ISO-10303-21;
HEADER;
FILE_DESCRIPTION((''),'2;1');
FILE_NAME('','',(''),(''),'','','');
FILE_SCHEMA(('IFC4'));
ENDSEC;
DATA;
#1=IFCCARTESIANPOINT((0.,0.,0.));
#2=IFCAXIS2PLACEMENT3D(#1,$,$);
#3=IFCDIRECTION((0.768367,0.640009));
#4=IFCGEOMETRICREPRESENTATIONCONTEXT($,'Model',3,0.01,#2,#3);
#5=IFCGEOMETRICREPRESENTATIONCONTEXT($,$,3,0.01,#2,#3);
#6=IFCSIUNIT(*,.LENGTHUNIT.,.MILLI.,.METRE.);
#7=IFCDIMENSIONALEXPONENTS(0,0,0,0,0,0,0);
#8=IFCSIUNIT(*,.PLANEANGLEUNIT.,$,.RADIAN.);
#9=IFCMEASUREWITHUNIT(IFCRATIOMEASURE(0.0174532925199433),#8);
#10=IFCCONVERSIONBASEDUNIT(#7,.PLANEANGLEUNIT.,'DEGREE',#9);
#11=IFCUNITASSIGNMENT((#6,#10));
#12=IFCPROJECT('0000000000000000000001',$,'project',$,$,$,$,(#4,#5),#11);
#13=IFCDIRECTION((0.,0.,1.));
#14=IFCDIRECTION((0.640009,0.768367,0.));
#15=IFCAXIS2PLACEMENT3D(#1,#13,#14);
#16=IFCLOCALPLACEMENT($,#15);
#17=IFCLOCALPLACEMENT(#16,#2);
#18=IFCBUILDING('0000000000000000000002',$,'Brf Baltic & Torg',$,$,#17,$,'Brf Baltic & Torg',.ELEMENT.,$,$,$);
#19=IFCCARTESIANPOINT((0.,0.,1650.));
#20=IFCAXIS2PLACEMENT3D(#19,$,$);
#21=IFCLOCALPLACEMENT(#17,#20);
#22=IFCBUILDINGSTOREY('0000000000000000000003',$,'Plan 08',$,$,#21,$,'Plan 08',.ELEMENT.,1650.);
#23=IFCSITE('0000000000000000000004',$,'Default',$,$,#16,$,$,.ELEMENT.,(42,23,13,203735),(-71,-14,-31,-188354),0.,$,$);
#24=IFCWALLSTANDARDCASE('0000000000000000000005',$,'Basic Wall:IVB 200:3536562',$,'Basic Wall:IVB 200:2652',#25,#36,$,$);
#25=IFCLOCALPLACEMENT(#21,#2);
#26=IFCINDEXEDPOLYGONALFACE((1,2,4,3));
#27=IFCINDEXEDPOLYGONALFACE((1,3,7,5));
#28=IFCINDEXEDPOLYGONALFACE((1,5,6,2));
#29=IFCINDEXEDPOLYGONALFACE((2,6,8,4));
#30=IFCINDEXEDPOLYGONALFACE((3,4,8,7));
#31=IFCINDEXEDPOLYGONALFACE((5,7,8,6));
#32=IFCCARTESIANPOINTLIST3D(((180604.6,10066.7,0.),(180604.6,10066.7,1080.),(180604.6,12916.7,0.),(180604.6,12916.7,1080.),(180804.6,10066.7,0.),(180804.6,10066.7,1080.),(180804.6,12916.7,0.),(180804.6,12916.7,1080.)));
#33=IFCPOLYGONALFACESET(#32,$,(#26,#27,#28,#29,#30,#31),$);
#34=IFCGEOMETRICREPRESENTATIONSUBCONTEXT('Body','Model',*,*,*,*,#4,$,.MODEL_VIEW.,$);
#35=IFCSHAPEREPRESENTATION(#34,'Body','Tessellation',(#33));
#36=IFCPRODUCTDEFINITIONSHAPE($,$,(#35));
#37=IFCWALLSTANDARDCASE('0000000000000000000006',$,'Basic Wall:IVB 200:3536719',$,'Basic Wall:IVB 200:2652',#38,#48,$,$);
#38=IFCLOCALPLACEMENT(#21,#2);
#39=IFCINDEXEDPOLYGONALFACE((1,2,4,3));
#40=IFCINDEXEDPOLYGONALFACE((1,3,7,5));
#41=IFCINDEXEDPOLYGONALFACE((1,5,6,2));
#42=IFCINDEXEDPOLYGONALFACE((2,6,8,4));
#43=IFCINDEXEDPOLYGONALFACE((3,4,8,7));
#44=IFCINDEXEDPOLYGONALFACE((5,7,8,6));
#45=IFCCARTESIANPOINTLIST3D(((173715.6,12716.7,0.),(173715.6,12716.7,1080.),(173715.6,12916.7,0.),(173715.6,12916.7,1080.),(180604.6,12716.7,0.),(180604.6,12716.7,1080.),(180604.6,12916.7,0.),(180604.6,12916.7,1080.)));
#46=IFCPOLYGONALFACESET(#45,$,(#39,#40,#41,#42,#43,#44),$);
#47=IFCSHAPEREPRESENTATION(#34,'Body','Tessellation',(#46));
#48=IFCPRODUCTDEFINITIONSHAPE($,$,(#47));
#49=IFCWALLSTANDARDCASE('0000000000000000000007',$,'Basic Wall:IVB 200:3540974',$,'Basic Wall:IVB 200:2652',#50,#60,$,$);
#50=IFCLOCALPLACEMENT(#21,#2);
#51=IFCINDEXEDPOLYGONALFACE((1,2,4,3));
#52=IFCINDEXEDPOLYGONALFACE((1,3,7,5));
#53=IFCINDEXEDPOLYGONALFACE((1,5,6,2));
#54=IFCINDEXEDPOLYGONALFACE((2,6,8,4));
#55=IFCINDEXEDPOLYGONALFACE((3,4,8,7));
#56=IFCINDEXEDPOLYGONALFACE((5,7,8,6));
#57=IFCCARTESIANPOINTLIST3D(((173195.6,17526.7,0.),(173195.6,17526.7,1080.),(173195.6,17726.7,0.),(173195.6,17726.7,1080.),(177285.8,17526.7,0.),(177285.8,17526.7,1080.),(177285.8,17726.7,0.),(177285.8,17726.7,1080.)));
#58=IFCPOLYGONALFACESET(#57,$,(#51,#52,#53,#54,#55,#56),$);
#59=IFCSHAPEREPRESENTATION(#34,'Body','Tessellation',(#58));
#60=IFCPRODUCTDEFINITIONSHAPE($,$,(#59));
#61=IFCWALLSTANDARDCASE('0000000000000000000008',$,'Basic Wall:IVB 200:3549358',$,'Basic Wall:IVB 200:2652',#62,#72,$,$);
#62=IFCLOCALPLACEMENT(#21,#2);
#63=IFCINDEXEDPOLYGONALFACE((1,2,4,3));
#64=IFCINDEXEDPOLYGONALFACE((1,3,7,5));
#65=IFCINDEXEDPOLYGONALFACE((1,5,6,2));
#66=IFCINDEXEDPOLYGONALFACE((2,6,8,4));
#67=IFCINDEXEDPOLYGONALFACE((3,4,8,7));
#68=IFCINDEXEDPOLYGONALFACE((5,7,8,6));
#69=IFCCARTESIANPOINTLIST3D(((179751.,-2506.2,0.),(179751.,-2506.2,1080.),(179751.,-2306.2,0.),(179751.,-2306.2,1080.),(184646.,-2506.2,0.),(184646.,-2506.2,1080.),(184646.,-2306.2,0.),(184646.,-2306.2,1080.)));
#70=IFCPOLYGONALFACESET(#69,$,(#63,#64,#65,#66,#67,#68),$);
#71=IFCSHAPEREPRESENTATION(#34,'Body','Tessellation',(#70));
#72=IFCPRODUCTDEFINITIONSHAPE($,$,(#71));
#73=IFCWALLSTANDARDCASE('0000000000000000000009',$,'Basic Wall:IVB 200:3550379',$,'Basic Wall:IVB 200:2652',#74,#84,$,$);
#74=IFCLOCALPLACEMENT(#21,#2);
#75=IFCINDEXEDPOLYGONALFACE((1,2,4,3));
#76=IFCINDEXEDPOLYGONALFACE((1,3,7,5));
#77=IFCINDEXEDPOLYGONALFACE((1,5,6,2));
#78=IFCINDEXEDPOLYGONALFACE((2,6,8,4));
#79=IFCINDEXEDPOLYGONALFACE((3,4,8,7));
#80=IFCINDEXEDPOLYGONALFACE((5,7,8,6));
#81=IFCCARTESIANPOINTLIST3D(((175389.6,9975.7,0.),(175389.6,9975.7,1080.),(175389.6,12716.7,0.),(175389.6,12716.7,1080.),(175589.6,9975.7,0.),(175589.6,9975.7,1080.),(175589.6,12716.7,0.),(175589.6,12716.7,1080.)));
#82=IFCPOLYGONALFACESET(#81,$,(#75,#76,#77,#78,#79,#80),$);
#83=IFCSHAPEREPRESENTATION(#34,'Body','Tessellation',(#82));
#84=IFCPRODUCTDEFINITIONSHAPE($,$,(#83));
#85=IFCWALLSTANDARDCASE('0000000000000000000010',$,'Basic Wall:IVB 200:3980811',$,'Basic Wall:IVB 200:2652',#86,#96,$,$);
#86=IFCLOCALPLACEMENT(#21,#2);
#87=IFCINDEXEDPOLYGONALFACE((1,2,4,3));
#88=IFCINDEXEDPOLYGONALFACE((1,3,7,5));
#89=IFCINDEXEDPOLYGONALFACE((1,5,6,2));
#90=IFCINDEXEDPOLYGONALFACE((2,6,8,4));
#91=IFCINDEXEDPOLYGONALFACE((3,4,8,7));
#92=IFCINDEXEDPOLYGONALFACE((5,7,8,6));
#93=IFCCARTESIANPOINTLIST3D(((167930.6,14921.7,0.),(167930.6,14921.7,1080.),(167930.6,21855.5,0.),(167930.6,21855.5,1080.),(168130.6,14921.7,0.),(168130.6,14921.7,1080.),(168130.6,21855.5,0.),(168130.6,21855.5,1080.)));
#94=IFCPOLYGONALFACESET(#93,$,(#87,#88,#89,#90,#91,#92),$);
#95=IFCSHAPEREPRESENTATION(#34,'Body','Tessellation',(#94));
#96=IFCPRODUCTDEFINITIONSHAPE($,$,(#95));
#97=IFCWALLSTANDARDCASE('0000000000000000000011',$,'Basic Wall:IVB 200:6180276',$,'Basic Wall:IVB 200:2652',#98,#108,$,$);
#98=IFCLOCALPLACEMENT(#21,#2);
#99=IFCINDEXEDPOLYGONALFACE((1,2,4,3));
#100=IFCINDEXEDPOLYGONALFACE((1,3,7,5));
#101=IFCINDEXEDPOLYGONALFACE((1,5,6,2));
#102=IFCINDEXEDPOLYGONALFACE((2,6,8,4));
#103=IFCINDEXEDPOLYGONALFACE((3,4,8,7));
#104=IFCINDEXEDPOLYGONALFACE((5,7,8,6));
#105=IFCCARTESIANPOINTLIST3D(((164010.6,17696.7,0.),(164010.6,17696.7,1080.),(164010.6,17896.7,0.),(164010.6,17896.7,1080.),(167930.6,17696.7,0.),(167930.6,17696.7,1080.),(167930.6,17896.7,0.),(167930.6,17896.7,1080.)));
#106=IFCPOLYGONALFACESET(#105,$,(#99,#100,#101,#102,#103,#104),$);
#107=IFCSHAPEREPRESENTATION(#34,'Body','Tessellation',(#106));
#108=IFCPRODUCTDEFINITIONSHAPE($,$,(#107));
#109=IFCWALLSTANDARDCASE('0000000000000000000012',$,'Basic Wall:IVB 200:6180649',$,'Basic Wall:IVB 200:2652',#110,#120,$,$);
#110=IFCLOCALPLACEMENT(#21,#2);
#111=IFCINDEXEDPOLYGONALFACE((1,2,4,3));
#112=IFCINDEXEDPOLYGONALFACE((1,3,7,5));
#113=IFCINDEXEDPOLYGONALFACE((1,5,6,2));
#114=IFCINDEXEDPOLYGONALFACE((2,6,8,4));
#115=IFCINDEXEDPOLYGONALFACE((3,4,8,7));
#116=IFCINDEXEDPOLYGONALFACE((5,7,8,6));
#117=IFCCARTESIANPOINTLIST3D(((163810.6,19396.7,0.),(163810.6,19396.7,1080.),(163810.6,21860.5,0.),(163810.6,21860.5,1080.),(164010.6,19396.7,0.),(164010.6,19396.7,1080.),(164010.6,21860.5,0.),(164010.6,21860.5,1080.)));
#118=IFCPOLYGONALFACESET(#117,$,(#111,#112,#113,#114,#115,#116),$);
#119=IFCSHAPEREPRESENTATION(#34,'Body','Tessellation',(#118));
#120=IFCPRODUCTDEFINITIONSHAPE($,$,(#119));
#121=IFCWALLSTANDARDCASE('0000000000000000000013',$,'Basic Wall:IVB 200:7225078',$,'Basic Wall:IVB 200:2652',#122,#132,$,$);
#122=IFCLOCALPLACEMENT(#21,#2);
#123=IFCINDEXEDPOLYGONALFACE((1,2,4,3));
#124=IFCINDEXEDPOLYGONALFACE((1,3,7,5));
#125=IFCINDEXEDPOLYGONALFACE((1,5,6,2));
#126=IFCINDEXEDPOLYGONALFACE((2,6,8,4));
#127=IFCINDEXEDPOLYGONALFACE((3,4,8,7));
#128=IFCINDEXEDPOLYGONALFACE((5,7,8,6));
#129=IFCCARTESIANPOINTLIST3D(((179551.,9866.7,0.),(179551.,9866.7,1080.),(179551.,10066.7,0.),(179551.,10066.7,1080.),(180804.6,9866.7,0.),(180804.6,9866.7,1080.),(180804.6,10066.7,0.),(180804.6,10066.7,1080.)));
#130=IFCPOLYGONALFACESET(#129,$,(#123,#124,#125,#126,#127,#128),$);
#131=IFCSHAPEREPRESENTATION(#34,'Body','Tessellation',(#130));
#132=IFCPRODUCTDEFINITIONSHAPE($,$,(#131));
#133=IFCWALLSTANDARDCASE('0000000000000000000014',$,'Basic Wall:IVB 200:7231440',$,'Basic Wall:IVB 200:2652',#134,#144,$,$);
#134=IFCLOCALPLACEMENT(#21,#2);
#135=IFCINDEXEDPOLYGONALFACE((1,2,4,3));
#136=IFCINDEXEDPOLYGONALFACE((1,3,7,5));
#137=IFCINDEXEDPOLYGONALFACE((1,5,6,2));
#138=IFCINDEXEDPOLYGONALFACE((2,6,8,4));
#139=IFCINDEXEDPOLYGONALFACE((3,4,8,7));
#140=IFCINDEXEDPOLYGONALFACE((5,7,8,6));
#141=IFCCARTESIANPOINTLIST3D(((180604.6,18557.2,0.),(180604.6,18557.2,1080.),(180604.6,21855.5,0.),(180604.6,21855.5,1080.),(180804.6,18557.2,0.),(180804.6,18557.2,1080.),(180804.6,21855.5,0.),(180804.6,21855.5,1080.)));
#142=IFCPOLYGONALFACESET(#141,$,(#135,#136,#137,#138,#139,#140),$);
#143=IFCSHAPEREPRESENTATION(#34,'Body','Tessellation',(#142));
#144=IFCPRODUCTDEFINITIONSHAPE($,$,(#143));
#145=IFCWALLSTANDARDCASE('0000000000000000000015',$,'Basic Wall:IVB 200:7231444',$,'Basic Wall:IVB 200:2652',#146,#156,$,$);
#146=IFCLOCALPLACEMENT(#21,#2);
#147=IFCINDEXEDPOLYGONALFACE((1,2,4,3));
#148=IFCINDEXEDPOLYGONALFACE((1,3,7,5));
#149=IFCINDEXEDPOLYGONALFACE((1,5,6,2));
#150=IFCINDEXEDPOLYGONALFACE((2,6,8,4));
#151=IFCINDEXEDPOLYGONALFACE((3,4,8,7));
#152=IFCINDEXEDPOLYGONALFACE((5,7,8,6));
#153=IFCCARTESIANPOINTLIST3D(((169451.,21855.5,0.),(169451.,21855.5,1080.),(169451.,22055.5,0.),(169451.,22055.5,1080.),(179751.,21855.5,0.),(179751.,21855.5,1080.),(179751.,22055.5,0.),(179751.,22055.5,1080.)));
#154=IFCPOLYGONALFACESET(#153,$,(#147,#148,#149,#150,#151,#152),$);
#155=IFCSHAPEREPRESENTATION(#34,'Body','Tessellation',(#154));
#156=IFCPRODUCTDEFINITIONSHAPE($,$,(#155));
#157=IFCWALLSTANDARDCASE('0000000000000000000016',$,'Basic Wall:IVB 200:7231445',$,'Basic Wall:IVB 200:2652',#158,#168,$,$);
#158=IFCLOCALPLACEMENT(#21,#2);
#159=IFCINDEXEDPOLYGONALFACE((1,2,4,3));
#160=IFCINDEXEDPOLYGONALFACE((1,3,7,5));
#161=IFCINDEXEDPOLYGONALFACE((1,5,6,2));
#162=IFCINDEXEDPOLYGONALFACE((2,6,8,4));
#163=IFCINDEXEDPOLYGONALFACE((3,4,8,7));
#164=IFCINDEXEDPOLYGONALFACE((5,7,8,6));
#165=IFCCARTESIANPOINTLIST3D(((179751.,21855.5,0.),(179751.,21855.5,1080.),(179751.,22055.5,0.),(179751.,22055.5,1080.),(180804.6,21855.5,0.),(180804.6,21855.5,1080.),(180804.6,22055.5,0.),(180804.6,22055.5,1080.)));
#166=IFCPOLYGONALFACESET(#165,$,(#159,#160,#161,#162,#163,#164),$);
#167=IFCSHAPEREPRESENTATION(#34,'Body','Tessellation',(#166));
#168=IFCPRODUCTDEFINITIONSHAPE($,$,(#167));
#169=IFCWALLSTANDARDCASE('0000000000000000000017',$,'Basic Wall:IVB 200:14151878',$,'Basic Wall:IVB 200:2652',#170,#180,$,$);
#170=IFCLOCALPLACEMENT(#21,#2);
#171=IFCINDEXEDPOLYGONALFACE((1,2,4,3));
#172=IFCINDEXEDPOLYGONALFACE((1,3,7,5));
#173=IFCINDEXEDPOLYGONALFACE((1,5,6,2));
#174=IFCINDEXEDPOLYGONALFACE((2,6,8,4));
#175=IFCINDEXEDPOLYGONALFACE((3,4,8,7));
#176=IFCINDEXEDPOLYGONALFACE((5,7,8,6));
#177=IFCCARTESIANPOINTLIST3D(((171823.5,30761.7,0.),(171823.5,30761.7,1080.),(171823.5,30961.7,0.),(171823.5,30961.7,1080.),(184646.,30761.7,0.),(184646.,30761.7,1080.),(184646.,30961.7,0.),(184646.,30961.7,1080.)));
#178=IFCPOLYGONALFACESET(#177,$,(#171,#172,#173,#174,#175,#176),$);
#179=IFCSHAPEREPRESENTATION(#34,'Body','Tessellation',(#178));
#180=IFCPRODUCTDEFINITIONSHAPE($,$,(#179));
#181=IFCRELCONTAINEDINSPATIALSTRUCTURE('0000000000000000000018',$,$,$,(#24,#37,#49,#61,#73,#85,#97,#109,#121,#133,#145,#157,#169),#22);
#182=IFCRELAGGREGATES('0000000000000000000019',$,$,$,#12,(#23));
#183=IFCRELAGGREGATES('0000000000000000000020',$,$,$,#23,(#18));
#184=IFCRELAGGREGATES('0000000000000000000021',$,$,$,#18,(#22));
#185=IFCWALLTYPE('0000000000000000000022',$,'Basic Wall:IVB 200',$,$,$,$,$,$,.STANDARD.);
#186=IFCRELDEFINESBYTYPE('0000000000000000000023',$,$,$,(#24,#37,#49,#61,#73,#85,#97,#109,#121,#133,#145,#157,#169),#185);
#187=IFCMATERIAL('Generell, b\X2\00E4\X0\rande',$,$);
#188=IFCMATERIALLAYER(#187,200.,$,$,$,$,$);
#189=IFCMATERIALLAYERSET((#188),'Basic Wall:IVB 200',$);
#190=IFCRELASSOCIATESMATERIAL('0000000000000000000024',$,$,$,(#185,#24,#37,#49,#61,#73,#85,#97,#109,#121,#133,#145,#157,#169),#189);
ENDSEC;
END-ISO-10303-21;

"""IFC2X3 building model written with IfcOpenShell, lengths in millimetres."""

from ifc_helpers import new_model, entity, si_unit, converted_unit, direction, frame, frame_2d, origin, place, context, subcontext, project, spatial, rectangle, extrude, clip, halfspace, material, layer, layer_set, layer_usage, type_object, element, save


model = new_model("IFC2X3")

# Units and contexts
model_context = context("Model", 3, precision=0.01, world=origin(), true_north=direction((0.768367, 0.640009)))
context_of_model = context(None, 3, precision=0.01, world=origin(), true_north=direction((0.768367, 0.640009)))
body_context = subcontext(model_context, "Body", "Model", "MODEL_VIEW")
ifc_project = project(units=[si_unit("LENGTHUNIT", "METRE", prefix="MILLI"), converted_unit("PLANEANGLEUNIT", "DEGREE", entity("IfcRatioMeasure", 0.0174532925199433), si_unit("PLANEANGLEUNIT", "RADIAN"), dimensions=[0, 0, 0, 0, 0, 0, 0])], contexts=[model_context, context_of_model])

# Site, building, storey
site_placement = place(None, frame((0.0, 0.0, 0.0), z_axis=(0.0, 0.0, 1.0), x_axis=(0.640009, 0.768367, 0.0)))
site = spatial("IfcSite", under=ifc_project, at=site_placement, Name="Default", CompositionType="ELEMENT", RefLatitude=(42, 23, 13, 203735), RefLongitude=(-71, -14, -31, -188354), RefElevation=0.0)
building_placement = place(site_placement, origin())
building = spatial("IfcBuilding", under=site, at=building_placement, Name="Brf Baltic & Torg", LongName="Brf Baltic & Torg", CompositionType="ELEMENT")
storey_placement = place(building_placement, frame((0.0, 0.0, 1650.0)))
storey = spatial("IfcBuildingStorey", under=building, at=storey_placement, Name="Plan 08", LongName="Plan 08", CompositionType="ELEMENT", Elevation=1650.0)

# Shared definitions
ifc_material_1 = material(Name="Generell, bärande")
ifc_layer = layer(ifc_material_1, 200.0)
ifc_layer_set = layer_set([ifc_layer], Name="Basic Wall:IVB 200")
wall_type = type_object("IfcWallType", Name="Basic Wall:IVB 200", PredefinedType="STANDARD", material=ifc_layer_set)

# Walls
ifc_layer_usage_1 = layer_usage(ifc_layer_set, "AXIS2", "POSITIVE", -100.0)
wall_1_placement = place(storey_placement, frame((180704.6, 10066.7, 0.0), z_axis=(0.0, 0.0, 1.0), x_axis=(0.0, 1.0, 0.0)))
element("IfcWallStandardCase", 1, at=wall_1_placement, inside=storey, type_object=wall_type, material=ifc_layer_usage_1, Name="Basic Wall:IVB 200:3536562", ObjectType="Basic Wall:IVB 200:2652", context=body_context, shape_type="Clipping", body=[
    clip(extrude(rectangle(XDim=2850.0, YDim=200.0, at=frame_2d((1425.0, 0.0), x_axis=(-1.0, 0.0))), origin(), (0.0, 0.0, 1.0), 1080.0), halfspace(origin(), True)),
])
ifc_layer_usage_2 = layer_usage(ifc_layer_set, "AXIS2", "NEGATIVE", 100.0)
wall_2_placement = place(storey_placement, frame((173715.6, 12816.7, 0.0)))
element("IfcWallStandardCase", 2, at=wall_2_placement, inside=storey, type_object=wall_type, material=ifc_layer_usage_2, Name="Basic Wall:IVB 200:3536719", ObjectType="Basic Wall:IVB 200:2652", context=body_context, shape_type="Clipping", body=[
    clip(extrude(rectangle(XDim=6889.0, YDim=200.0, at=frame_2d((3444.5, 0.0), x_axis=(-1.0, 0.0))), origin(), (0.0, 0.0, 1.0), 1080.0), halfspace(origin(), True)),
])
ifc_layer_usage_3 = layer_usage(ifc_layer_set, "AXIS2", "NEGATIVE", 100.0)
wall_3_placement = place(storey_placement, frame((173195.6, 17626.7, 0.0)))
element("IfcWallStandardCase", 3, at=wall_3_placement, inside=storey, type_object=wall_type, material=ifc_layer_usage_3, Name="Basic Wall:IVB 200:3540974", ObjectType="Basic Wall:IVB 200:2652", context=body_context, shape_type="Clipping", body=[
    clip(extrude(rectangle(XDim=4090.2, YDim=200.0, at=frame_2d((2045.1, 0.0), x_axis=(-1.0, 0.0))), origin(), (0.0, 0.0, 1.0), 1080.0), halfspace(origin(), True)),
])
ifc_layer_usage_4 = layer_usage(ifc_layer_set, "AXIS2", "NEGATIVE", 100.0)
wall_4_placement = place(storey_placement, frame((179751.0, -2406.2, 0.0)))
element("IfcWallStandardCase", 4, at=wall_4_placement, inside=storey, type_object=wall_type, material=ifc_layer_usage_4, Name="Basic Wall:IVB 200:3549358", ObjectType="Basic Wall:IVB 200:2652", context=body_context, shape_type="Clipping", body=[
    clip(extrude(rectangle(XDim=4895.0, YDim=200.0, at=frame_2d((2447.5, 0.0), x_axis=(-1.0, 0.0))), origin(), (0.0, 0.0, 1.0), 1080.0), halfspace(origin(), True)),
])
ifc_layer_usage_5 = layer_usage(ifc_layer_set, "AXIS2", "POSITIVE", -100.0)
wall_5_placement = place(storey_placement, frame((175489.6, 9975.7, 0.0), z_axis=(0.0, 0.0, 1.0), x_axis=(0.0, 1.0, 0.0)))
element("IfcWallStandardCase", 5, at=wall_5_placement, inside=storey, type_object=wall_type, material=ifc_layer_usage_5, Name="Basic Wall:IVB 200:3550379", ObjectType="Basic Wall:IVB 200:2652", context=body_context, shape_type="Clipping", body=[
    clip(extrude(rectangle(XDim=2741.0, YDim=200.0, at=frame_2d((1370.5, 0.0), x_axis=(-1.0, 0.0))), origin(), (0.0, 0.0, 1.0), 1080.0), halfspace(origin(), True)),
])

# Walls
ifc_layer_usage_6 = layer_usage(ifc_layer_set, "AXIS2", "NEGATIVE", 100.0)
wall_6_placement = place(storey_placement, frame((168030.6, 21855.5, 0.0), z_axis=(0.0, 0.0, 1.0), x_axis=(0.0, -1.0, 0.0)))
element("IfcWallStandardCase", 6, at=wall_6_placement, inside=storey, type_object=wall_type, material=ifc_layer_usage_6, Name="Basic Wall:IVB 200:3980811", ObjectType="Basic Wall:IVB 200:2652", context=body_context, shape_type="Clipping", body=[
    clip(extrude(rectangle(XDim=6933.7, YDim=200.0, at=frame_2d((3466.9, 0.0), x_axis=(-1.0, 0.0))), origin(), (0.0, 0.0, 1.0), 1080.0), halfspace(origin(), True)),
])
ifc_layer_usage_7 = layer_usage(ifc_layer_set, "AXIS2", "POSITIVE", -100.0)
wall_7_placement = place(storey_placement, frame((167930.6, 17796.7, 0.0), z_axis=(0.0, 0.0, 1.0), x_axis=(-1.0, 0.0, 0.0)))
element("IfcWallStandardCase", 7, at=wall_7_placement, inside=storey, type_object=wall_type, material=ifc_layer_usage_7, Name="Basic Wall:IVB 200:6180276", ObjectType="Basic Wall:IVB 200:2652", context=body_context, shape_type="Clipping", body=[
    clip(extrude(rectangle(XDim=3920.0, YDim=200.0, at=frame_2d((1960.0, 0.0), x_axis=(-1.0, 0.0))), origin(), (0.0, 0.0, 1.0), 1080.0), halfspace(origin(), True)),
])
ifc_layer_usage_8 = layer_usage(ifc_layer_set, "AXIS2", "NEGATIVE", 100.0)
wall_8_placement = place(storey_placement, frame((163910.6, 19396.7, 0.0), z_axis=(0.0, 0.0, 1.0), x_axis=(0.0, 1.0, 0.0)))
element("IfcWallStandardCase", 8, at=wall_8_placement, inside=storey, type_object=wall_type, material=ifc_layer_usage_8, Name="Basic Wall:IVB 200:6180649", ObjectType="Basic Wall:IVB 200:2652", context=body_context, shape_type="Clipping", body=[
    clip(extrude(rectangle(XDim=2463.7, YDim=200.0, at=frame_2d((1231.9, 0.0), x_axis=(-1.0, 0.0))), origin(), (0.0, 0.0, 1.0), 1080.0), halfspace(origin(), True)),
])
ifc_layer_usage_9 = layer_usage(ifc_layer_set, "AXIS2", "NEGATIVE", 100.0)
wall_9_placement = place(storey_placement, frame((180804.6, 9966.7, 0.0), z_axis=(0.0, 0.0, 1.0), x_axis=(-1.0, 0.0, 0.0)))
element("IfcWallStandardCase", 9, at=wall_9_placement, inside=storey, type_object=wall_type, material=ifc_layer_usage_9, Name="Basic Wall:IVB 200:7225078", ObjectType="Basic Wall:IVB 200:2652", context=body_context, shape_type="Clipping", body=[
    clip(extrude(rectangle(XDim=1253.6, YDim=200.0, at=frame_2d((626.8, 0.0), x_axis=(-1.0, 0.0))), origin(), (0.0, 0.0, 1.0), 1080.0), halfspace(origin(), True)),
])
ifc_layer_usage_10 = layer_usage(ifc_layer_set, "AXIS2", "POSITIVE", -100.0)
wall_10_placement = place(storey_placement, frame((180704.6, 18557.2, 0.0), z_axis=(0.0, 0.0, 1.0), x_axis=(0.0, 1.0, 0.0)))
element("IfcWallStandardCase", 10, at=wall_10_placement, inside=storey, type_object=wall_type, material=ifc_layer_usage_10, Name="Basic Wall:IVB 200:7231440", ObjectType="Basic Wall:IVB 200:2652", context=body_context, shape_type="Clipping", body=[
    clip(extrude(rectangle(XDim=3298.3, YDim=200.0, at=frame_2d((1649.1, 0.0), x_axis=(-1.0, 0.0))), origin(), (0.0, 0.0, 1.0), 1080.0), halfspace(origin(), True)),
])
ifc_layer_usage_11 = layer_usage(ifc_layer_set, "AXIS2", "NEGATIVE", 100.0)
wall_11_placement = place(storey_placement, frame((169451.0, 21955.5, 0.0)))
element("IfcWallStandardCase", 11, at=wall_11_placement, inside=storey, type_object=wall_type, material=ifc_layer_usage_11, Name="Basic Wall:IVB 200:7231444", ObjectType="Basic Wall:IVB 200:2652", context=body_context, shape_type="Clipping", body=[
    clip(extrude(rectangle(XDim=10300.0, YDim=200.0, at=frame_2d((5150.0, 0.0), x_axis=(-1.0, 0.0))), origin(), (0.0, 0.0, 1.0), 1080.0), halfspace(origin(), True)),
])
ifc_layer_usage_12 = layer_usage(ifc_layer_set, "AXIS2", "NEGATIVE", 100.0)
wall_12_placement = place(storey_placement, frame((179751.0, 21955.5, 0.0)))
element("IfcWallStandardCase", 12, at=wall_12_placement, inside=storey, type_object=wall_type, material=ifc_layer_usage_12, Name="Basic Wall:IVB 200:7231445", ObjectType="Basic Wall:IVB 200:2652", context=body_context, shape_type="Clipping", body=[
    clip(extrude(rectangle(XDim=1053.6, YDim=200.0, at=frame_2d((526.8, 0.0), x_axis=(-1.0, 0.0))), origin(), (0.0, 0.0, 1.0), 1080.0), halfspace(origin(), True)),
])
ifc_layer_usage_13 = layer_usage(ifc_layer_set, "AXIS2", "NEGATIVE", 100.0)
wall_13_placement = place(storey_placement, frame((184646.0, 30861.7, 0.0), z_axis=(0.0, 0.0, 1.0), x_axis=(-1.0, 0.0, 0.0)))
element("IfcWallStandardCase", 13, at=wall_13_placement, inside=storey, type_object=wall_type, material=ifc_layer_usage_13, Name="Basic Wall:IVB 200:14151878", ObjectType="Basic Wall:IVB 200:2652", context=body_context, shape_type="Clipping", body=[
    clip(extrude(rectangle(XDim=12822.5, YDim=200.0, at=frame_2d((6411.3, 0.0), x_axis=(-1.0, 0.0))), origin(), (0.0, 0.0, 1.0), 1080.0), halfspace(origin(), True)),
])

save(model, "model.ifc")
